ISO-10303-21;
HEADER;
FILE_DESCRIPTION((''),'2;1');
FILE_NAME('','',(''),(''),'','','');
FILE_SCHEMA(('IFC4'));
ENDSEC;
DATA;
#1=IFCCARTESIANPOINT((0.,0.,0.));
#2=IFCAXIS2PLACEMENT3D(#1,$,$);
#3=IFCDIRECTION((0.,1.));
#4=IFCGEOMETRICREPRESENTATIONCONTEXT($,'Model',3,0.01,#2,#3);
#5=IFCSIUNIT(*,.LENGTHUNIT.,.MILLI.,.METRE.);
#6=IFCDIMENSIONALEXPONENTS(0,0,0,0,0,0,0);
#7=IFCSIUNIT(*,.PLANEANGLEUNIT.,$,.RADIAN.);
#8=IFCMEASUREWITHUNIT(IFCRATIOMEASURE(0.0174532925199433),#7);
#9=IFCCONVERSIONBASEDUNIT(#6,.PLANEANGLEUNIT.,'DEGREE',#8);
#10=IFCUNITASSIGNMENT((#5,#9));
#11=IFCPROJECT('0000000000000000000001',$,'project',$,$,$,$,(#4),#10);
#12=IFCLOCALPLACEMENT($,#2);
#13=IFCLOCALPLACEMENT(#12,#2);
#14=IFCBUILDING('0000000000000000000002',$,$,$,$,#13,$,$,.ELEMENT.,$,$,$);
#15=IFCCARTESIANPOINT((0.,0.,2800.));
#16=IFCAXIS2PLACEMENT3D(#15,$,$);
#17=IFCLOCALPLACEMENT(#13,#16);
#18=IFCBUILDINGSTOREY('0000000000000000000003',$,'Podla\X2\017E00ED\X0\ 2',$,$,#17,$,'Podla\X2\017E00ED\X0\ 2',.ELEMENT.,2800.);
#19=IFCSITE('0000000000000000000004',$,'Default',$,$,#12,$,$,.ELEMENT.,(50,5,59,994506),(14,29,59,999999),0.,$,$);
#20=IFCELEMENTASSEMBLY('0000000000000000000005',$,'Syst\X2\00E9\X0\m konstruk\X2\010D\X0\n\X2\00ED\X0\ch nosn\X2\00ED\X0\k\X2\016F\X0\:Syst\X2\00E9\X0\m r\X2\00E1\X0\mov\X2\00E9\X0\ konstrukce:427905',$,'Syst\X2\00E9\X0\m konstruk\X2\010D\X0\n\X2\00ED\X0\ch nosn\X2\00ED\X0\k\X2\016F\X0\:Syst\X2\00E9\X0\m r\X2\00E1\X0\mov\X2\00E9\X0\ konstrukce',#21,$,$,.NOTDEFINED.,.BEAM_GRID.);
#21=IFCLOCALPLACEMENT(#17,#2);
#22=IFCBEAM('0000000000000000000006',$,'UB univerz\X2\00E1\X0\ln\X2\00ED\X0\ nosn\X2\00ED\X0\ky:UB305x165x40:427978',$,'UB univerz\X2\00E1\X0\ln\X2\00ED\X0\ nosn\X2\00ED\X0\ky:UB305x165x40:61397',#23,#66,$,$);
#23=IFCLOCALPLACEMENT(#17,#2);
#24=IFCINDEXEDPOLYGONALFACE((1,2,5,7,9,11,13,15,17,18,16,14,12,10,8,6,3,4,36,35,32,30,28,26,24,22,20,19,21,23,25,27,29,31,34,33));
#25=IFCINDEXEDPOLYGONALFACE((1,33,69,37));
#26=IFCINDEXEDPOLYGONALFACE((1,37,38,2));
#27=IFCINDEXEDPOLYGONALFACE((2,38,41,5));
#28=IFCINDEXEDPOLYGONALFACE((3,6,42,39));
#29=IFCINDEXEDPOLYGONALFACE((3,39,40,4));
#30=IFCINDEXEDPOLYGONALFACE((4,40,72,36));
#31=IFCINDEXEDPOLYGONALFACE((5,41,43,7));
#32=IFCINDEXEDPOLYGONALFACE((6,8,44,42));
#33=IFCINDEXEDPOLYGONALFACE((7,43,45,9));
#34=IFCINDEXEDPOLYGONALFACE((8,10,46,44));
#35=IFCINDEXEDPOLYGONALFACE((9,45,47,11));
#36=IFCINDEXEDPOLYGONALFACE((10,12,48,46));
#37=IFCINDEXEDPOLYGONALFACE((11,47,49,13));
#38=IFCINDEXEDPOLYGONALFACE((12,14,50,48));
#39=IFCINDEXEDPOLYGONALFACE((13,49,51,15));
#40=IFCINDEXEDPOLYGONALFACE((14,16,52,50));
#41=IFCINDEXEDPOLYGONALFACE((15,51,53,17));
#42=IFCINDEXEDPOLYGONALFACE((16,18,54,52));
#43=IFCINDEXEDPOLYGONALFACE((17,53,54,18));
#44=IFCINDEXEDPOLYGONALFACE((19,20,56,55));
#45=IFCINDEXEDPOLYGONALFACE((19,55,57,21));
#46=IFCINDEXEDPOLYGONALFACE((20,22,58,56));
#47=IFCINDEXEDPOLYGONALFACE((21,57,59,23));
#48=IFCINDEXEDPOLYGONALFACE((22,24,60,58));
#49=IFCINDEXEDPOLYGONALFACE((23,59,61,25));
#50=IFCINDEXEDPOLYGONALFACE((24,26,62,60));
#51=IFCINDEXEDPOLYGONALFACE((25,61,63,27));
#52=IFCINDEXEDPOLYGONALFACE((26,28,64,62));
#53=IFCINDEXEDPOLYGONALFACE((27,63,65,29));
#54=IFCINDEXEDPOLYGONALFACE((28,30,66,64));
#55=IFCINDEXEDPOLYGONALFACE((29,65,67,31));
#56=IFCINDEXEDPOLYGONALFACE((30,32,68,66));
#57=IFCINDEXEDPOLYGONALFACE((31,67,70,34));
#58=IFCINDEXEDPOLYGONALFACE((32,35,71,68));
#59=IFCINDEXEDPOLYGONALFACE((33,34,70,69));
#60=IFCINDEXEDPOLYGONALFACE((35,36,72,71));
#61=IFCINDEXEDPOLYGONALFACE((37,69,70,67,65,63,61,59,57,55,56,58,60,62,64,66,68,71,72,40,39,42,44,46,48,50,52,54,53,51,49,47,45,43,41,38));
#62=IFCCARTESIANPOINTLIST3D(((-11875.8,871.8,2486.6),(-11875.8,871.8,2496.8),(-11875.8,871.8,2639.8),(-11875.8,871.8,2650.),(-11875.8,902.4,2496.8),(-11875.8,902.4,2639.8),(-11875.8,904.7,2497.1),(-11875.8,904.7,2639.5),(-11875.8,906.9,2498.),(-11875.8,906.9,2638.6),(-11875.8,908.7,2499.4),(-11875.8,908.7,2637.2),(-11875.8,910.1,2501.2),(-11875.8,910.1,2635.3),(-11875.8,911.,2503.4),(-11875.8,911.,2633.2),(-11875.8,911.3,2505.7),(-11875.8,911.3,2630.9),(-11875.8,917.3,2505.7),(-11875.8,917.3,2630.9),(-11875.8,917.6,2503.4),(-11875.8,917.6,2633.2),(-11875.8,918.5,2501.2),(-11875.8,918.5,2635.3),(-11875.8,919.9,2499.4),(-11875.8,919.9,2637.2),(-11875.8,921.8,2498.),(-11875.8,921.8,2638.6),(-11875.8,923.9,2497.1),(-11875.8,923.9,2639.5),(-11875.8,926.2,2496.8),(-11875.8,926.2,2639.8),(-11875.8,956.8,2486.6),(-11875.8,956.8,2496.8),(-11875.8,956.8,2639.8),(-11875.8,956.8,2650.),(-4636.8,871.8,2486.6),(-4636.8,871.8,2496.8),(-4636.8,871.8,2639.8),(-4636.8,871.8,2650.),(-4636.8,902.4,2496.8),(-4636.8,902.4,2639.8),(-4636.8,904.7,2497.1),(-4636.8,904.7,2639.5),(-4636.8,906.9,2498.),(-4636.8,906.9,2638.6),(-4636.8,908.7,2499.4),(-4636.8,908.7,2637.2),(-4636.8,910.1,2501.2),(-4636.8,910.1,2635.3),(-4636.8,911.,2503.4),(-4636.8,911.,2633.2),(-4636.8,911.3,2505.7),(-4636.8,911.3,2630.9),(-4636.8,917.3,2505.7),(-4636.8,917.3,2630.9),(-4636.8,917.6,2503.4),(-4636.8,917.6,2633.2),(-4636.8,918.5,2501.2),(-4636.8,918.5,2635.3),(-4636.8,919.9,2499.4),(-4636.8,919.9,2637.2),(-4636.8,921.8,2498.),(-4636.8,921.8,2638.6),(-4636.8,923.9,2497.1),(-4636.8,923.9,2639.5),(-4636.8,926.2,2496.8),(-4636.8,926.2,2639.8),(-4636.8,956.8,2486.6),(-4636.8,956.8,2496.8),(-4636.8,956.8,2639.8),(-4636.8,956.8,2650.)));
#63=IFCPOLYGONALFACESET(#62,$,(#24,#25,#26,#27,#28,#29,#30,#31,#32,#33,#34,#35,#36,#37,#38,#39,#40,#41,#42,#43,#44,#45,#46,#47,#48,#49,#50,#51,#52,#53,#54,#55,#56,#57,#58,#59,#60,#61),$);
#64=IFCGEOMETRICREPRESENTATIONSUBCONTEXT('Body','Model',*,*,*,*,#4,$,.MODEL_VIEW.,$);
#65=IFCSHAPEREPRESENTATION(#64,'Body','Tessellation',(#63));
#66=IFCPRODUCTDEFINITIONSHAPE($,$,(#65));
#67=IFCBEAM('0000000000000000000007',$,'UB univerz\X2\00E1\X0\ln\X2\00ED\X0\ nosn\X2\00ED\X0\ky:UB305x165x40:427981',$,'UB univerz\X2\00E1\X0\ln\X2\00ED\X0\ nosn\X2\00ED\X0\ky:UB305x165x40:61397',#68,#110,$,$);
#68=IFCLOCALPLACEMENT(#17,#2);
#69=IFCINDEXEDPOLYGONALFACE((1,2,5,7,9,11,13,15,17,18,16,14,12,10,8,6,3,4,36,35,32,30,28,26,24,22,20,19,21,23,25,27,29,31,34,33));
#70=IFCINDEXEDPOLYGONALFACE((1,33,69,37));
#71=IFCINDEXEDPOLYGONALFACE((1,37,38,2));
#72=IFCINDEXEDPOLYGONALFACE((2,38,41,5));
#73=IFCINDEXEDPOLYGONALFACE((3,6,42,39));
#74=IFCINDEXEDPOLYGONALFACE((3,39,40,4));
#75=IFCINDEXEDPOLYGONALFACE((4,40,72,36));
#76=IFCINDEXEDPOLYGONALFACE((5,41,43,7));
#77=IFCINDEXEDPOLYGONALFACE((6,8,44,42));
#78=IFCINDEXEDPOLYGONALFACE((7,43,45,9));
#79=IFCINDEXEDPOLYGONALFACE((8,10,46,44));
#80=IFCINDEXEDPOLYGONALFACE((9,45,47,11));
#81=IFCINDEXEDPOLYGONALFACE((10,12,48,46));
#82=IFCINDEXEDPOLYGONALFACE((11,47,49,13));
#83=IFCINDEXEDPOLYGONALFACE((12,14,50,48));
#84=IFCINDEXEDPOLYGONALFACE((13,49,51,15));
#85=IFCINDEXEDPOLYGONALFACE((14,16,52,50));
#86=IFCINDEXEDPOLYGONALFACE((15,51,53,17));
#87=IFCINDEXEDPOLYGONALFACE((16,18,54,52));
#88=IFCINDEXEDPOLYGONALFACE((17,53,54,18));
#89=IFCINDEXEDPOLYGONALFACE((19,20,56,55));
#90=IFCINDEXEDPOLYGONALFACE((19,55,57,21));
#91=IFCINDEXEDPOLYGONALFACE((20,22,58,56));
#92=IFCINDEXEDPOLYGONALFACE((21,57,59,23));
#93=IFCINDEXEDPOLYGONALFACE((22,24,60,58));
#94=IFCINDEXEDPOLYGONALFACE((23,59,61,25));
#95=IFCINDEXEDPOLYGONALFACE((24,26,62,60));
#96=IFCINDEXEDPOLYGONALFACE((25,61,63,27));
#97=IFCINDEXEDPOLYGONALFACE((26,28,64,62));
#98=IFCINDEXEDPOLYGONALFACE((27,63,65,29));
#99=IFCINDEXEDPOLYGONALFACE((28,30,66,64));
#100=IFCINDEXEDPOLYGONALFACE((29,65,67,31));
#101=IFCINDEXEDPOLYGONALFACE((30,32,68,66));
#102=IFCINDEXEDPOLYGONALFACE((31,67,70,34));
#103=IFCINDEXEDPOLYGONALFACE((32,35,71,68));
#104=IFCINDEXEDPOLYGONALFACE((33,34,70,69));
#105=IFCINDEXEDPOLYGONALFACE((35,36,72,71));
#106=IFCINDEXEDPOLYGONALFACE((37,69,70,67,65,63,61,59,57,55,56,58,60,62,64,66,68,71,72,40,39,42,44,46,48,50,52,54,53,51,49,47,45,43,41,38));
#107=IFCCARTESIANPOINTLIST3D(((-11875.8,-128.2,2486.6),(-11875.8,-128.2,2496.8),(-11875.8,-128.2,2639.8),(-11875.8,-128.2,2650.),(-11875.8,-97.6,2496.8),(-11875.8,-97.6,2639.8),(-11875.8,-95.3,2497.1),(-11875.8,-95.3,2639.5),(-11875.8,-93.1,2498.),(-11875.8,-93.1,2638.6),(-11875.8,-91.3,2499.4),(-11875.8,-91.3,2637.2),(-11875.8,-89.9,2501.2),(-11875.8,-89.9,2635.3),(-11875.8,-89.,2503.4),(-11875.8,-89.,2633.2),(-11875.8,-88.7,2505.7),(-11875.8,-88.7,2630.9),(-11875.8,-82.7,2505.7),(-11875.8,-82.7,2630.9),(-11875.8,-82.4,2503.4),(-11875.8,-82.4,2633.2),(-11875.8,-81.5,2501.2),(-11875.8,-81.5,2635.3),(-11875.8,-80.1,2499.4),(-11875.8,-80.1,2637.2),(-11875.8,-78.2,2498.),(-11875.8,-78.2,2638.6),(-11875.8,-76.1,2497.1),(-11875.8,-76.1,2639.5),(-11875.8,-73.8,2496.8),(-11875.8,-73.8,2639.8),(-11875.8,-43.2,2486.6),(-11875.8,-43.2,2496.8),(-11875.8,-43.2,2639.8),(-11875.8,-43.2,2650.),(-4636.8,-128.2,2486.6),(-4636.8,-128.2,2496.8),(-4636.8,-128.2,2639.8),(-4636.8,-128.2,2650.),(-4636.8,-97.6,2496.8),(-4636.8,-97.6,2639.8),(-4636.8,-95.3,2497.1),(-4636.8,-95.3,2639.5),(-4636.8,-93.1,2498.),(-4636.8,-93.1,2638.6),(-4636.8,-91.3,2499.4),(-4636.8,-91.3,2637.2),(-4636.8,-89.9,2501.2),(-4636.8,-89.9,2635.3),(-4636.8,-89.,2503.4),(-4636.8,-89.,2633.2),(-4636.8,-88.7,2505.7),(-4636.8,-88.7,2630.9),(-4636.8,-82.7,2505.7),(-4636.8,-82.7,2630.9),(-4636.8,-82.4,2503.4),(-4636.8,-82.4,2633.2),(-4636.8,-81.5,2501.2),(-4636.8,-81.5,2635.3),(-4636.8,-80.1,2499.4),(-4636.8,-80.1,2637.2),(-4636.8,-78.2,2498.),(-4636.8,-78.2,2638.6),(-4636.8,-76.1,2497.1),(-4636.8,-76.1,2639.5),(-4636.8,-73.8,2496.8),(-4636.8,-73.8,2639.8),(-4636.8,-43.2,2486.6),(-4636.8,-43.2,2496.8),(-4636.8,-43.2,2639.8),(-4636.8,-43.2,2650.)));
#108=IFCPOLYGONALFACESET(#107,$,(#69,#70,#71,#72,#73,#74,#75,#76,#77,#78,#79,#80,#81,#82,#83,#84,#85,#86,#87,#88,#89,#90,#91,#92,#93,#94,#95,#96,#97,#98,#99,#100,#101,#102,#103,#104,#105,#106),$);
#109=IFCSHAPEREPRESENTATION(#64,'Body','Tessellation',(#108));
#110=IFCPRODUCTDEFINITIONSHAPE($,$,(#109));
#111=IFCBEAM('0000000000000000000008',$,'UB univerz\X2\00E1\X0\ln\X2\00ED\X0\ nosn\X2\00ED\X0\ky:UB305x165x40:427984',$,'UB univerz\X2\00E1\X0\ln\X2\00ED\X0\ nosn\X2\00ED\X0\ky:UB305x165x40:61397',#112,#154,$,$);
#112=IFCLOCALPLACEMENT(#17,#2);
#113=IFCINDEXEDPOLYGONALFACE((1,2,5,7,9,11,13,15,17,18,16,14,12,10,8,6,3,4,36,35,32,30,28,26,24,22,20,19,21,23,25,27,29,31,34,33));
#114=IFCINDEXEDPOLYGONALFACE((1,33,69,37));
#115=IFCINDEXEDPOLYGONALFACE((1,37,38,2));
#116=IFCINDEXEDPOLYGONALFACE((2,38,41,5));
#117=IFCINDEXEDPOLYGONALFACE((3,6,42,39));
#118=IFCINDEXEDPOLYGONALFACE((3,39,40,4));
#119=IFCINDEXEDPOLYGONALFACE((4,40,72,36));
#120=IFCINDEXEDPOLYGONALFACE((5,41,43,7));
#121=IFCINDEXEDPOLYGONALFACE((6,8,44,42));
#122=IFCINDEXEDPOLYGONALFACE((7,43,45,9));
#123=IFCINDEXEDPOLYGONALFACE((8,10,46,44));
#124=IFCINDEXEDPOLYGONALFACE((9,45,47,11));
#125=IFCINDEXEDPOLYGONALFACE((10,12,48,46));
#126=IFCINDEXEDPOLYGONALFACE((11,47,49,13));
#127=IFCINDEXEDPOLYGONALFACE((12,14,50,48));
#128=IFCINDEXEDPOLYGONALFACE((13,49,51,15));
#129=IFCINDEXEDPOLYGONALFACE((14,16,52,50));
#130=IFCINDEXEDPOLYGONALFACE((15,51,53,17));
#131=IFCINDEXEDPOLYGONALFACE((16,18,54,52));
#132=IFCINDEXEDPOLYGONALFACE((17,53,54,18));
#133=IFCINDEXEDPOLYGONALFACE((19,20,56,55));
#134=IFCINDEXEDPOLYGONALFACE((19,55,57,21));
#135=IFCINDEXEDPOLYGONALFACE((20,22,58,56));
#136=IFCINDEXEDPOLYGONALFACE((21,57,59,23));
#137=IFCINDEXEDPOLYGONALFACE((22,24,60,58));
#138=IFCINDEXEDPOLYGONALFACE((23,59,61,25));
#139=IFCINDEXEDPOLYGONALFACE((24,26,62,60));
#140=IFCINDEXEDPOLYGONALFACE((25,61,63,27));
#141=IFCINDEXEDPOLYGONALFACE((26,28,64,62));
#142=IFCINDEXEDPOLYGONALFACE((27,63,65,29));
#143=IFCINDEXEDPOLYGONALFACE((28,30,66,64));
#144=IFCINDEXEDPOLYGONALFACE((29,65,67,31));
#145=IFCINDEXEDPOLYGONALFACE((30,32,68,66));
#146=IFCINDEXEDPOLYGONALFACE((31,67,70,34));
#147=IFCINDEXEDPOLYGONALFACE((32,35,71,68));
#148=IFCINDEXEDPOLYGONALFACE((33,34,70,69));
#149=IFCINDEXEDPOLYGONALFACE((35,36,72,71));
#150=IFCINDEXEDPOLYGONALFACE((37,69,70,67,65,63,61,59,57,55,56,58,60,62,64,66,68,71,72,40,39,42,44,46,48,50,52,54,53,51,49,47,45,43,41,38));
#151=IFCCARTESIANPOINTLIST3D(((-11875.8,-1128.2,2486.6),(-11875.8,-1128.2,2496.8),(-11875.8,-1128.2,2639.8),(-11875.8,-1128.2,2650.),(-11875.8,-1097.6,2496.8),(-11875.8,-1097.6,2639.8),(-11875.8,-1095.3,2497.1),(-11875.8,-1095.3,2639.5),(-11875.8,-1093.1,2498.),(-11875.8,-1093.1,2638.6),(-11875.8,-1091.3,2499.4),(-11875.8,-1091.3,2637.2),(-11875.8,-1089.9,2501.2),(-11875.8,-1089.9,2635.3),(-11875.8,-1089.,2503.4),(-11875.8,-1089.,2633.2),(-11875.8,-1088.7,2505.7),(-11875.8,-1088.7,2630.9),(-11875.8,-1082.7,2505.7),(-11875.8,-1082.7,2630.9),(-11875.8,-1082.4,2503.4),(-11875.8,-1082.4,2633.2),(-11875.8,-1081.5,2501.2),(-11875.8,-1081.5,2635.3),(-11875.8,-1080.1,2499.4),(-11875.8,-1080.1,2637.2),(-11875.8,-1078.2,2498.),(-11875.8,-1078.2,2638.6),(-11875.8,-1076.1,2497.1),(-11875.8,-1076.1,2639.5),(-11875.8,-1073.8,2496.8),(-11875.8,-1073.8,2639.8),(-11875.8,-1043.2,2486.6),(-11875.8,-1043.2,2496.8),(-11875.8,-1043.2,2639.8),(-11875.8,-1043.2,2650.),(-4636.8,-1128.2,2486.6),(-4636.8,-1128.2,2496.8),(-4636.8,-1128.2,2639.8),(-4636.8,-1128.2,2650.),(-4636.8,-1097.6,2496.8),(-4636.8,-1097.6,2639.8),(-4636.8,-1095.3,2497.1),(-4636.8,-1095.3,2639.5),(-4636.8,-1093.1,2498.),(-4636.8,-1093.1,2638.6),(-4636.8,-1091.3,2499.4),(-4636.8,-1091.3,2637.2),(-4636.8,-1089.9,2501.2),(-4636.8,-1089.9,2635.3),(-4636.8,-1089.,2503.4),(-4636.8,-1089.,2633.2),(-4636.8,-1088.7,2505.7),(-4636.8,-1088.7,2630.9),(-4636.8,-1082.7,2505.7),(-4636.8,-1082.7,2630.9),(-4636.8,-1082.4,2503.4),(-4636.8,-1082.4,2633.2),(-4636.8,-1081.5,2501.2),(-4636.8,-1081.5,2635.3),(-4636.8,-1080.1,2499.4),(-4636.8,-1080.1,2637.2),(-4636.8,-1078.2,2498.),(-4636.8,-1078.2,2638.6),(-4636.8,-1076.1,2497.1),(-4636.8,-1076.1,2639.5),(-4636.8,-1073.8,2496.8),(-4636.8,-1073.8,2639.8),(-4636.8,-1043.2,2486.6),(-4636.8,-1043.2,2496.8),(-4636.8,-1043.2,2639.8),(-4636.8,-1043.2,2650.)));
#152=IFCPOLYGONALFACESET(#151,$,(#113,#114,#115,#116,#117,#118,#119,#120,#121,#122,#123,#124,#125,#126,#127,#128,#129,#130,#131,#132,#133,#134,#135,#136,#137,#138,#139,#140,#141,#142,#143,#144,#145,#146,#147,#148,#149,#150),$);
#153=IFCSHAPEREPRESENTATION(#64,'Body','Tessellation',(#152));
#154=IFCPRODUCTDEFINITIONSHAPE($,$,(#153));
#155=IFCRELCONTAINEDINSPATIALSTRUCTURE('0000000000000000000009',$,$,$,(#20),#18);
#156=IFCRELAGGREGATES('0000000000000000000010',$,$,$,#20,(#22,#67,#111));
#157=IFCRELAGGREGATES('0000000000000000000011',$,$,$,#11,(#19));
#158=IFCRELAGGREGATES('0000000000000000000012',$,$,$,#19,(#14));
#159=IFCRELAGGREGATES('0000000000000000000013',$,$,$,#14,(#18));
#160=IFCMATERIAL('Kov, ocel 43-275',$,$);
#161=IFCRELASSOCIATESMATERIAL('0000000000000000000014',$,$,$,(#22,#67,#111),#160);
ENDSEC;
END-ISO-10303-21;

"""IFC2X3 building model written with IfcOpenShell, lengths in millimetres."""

from ifc_helpers import new_model, entity, si_unit, converted_unit, direction, frame, frame_2d, origin, place, context, subcontext, project, spatial, i_section, extrude, material, element, aggregate, save


model = new_model("IFC2X3")

# Units and contexts
model_context = context("Model", 3, precision=0.01, world=origin(), true_north=direction((0.0, 1.0)))
body_context = subcontext(model_context, "Body", "Model", "MODEL_VIEW")
ifc_project = project(units=[si_unit("LENGTHUNIT", "METRE", prefix="MILLI"), converted_unit("PLANEANGLEUNIT", "DEGREE", entity("IfcRatioMeasure", 0.0174532925199433), si_unit("PLANEANGLEUNIT", "RADIAN"), dimensions=[0, 0, 0, 0, 0, 0, 0])], contexts=[model_context])

# Site, building, storey
site_placement = place(None, origin())
site = spatial("IfcSite", under=ifc_project, at=site_placement, Name="Default", CompositionType="ELEMENT", RefLatitude=(50, 5, 59, 994506), RefLongitude=(14, 29, 59, 999999), RefElevation=0.0)
building_placement = place(site_placement, origin())
building = spatial("IfcBuilding", under=site, at=building_placement, CompositionType="ELEMENT")
storey_placement = place(building_placement, frame((0.0, 0.0, 2800.0)))
storey = spatial("IfcBuildingStorey", under=building, at=storey_placement, Name="Podlaží 2", LongName="Podlaží 2", CompositionType="ELEMENT", Elevation=2800.0)

# Element assembly, beams
ifc_material = material(Name="Kov, ocel 43-275")
assembly_1_placement = place(storey_placement, origin())
assembly_1 = element("IfcElementAssembly", 1, at=assembly_1_placement, inside=storey, Name="Systém konstrukčních nosníků:Systém rámové konstrukce:427905", ObjectType="Systém konstrukčních nosníků:Systém rámové konstrukce", AssemblyPlace="NOTDEFINED", PredefinedType="BEAM_GRID")
beam_1_placement = place(assembly_1_placement, frame((-11875.8, 914.3, 0.0)))
beam_1 = element("IfcBeam", 2, at=beam_1_placement, material=ifc_material, Name="UB univerzální nosníky:UB305x165x40:427978", ObjectType="UB univerzální nosníky:UB305x165x40:61397", context=body_context, shape_type="SweptSolid", body=[
    extrude(i_section(OverallWidth=85.0, OverallDepth=163.4, WebThickness=6.0, FlangeThickness=10.2, FilletRadius=8.9, at=frame_2d((0.0, 0.0), x_axis=(0.0, 1.0))), frame((0.0, 0.0, 2568.3), z_axis=(1.0, 0.0, 0.0), x_axis=(0.0, 0.0, -1.0)), (0.0, 0.0, 1.0), 7239.0),
])
beam_2_placement = place(assembly_1_placement, frame((-11875.8, -85.7, 0.0)))
beam_2 = element("IfcBeam", 3, at=beam_2_placement, material=ifc_material, Name="UB univerzální nosníky:UB305x165x40:427981", ObjectType="UB univerzální nosníky:UB305x165x40:61397", context=body_context, shape_type="SweptSolid", body=[
    extrude(i_section(OverallWidth=85.0, OverallDepth=163.4, WebThickness=6.0, FlangeThickness=10.2, FilletRadius=8.9, at=frame_2d((0.0, 0.0), x_axis=(0.0, 1.0))), frame((0.0, 0.0, 2568.3), z_axis=(1.0, 0.0, 0.0), x_axis=(0.0, 0.0, -1.0)), (0.0, 0.0, 1.0), 7239.0),
])
beam_3_placement = place(assembly_1_placement, frame((-11875.8, -1085.7, 0.0)))
beam_3 = element("IfcBeam", 4, at=beam_3_placement, material=ifc_material, Name="UB univerzální nosníky:UB305x165x40:427984", ObjectType="UB univerzální nosníky:UB305x165x40:61397", context=body_context, shape_type="SweptSolid", body=[
    extrude(i_section(OverallWidth=85.0, OverallDepth=163.4, WebThickness=6.0, FlangeThickness=10.2, FilletRadius=8.9, at=frame_2d((0.0, 0.0), x_axis=(0.0, 1.0))), frame((0.0, 0.0, 2568.3), z_axis=(1.0, 0.0, 0.0), x_axis=(0.0, 0.0, -1.0)), (0.0, 0.0, 1.0), 7239.0),
])
aggregate(assembly_1, [beam_1, beam_2, beam_3])

save(model, "model.ifc")
